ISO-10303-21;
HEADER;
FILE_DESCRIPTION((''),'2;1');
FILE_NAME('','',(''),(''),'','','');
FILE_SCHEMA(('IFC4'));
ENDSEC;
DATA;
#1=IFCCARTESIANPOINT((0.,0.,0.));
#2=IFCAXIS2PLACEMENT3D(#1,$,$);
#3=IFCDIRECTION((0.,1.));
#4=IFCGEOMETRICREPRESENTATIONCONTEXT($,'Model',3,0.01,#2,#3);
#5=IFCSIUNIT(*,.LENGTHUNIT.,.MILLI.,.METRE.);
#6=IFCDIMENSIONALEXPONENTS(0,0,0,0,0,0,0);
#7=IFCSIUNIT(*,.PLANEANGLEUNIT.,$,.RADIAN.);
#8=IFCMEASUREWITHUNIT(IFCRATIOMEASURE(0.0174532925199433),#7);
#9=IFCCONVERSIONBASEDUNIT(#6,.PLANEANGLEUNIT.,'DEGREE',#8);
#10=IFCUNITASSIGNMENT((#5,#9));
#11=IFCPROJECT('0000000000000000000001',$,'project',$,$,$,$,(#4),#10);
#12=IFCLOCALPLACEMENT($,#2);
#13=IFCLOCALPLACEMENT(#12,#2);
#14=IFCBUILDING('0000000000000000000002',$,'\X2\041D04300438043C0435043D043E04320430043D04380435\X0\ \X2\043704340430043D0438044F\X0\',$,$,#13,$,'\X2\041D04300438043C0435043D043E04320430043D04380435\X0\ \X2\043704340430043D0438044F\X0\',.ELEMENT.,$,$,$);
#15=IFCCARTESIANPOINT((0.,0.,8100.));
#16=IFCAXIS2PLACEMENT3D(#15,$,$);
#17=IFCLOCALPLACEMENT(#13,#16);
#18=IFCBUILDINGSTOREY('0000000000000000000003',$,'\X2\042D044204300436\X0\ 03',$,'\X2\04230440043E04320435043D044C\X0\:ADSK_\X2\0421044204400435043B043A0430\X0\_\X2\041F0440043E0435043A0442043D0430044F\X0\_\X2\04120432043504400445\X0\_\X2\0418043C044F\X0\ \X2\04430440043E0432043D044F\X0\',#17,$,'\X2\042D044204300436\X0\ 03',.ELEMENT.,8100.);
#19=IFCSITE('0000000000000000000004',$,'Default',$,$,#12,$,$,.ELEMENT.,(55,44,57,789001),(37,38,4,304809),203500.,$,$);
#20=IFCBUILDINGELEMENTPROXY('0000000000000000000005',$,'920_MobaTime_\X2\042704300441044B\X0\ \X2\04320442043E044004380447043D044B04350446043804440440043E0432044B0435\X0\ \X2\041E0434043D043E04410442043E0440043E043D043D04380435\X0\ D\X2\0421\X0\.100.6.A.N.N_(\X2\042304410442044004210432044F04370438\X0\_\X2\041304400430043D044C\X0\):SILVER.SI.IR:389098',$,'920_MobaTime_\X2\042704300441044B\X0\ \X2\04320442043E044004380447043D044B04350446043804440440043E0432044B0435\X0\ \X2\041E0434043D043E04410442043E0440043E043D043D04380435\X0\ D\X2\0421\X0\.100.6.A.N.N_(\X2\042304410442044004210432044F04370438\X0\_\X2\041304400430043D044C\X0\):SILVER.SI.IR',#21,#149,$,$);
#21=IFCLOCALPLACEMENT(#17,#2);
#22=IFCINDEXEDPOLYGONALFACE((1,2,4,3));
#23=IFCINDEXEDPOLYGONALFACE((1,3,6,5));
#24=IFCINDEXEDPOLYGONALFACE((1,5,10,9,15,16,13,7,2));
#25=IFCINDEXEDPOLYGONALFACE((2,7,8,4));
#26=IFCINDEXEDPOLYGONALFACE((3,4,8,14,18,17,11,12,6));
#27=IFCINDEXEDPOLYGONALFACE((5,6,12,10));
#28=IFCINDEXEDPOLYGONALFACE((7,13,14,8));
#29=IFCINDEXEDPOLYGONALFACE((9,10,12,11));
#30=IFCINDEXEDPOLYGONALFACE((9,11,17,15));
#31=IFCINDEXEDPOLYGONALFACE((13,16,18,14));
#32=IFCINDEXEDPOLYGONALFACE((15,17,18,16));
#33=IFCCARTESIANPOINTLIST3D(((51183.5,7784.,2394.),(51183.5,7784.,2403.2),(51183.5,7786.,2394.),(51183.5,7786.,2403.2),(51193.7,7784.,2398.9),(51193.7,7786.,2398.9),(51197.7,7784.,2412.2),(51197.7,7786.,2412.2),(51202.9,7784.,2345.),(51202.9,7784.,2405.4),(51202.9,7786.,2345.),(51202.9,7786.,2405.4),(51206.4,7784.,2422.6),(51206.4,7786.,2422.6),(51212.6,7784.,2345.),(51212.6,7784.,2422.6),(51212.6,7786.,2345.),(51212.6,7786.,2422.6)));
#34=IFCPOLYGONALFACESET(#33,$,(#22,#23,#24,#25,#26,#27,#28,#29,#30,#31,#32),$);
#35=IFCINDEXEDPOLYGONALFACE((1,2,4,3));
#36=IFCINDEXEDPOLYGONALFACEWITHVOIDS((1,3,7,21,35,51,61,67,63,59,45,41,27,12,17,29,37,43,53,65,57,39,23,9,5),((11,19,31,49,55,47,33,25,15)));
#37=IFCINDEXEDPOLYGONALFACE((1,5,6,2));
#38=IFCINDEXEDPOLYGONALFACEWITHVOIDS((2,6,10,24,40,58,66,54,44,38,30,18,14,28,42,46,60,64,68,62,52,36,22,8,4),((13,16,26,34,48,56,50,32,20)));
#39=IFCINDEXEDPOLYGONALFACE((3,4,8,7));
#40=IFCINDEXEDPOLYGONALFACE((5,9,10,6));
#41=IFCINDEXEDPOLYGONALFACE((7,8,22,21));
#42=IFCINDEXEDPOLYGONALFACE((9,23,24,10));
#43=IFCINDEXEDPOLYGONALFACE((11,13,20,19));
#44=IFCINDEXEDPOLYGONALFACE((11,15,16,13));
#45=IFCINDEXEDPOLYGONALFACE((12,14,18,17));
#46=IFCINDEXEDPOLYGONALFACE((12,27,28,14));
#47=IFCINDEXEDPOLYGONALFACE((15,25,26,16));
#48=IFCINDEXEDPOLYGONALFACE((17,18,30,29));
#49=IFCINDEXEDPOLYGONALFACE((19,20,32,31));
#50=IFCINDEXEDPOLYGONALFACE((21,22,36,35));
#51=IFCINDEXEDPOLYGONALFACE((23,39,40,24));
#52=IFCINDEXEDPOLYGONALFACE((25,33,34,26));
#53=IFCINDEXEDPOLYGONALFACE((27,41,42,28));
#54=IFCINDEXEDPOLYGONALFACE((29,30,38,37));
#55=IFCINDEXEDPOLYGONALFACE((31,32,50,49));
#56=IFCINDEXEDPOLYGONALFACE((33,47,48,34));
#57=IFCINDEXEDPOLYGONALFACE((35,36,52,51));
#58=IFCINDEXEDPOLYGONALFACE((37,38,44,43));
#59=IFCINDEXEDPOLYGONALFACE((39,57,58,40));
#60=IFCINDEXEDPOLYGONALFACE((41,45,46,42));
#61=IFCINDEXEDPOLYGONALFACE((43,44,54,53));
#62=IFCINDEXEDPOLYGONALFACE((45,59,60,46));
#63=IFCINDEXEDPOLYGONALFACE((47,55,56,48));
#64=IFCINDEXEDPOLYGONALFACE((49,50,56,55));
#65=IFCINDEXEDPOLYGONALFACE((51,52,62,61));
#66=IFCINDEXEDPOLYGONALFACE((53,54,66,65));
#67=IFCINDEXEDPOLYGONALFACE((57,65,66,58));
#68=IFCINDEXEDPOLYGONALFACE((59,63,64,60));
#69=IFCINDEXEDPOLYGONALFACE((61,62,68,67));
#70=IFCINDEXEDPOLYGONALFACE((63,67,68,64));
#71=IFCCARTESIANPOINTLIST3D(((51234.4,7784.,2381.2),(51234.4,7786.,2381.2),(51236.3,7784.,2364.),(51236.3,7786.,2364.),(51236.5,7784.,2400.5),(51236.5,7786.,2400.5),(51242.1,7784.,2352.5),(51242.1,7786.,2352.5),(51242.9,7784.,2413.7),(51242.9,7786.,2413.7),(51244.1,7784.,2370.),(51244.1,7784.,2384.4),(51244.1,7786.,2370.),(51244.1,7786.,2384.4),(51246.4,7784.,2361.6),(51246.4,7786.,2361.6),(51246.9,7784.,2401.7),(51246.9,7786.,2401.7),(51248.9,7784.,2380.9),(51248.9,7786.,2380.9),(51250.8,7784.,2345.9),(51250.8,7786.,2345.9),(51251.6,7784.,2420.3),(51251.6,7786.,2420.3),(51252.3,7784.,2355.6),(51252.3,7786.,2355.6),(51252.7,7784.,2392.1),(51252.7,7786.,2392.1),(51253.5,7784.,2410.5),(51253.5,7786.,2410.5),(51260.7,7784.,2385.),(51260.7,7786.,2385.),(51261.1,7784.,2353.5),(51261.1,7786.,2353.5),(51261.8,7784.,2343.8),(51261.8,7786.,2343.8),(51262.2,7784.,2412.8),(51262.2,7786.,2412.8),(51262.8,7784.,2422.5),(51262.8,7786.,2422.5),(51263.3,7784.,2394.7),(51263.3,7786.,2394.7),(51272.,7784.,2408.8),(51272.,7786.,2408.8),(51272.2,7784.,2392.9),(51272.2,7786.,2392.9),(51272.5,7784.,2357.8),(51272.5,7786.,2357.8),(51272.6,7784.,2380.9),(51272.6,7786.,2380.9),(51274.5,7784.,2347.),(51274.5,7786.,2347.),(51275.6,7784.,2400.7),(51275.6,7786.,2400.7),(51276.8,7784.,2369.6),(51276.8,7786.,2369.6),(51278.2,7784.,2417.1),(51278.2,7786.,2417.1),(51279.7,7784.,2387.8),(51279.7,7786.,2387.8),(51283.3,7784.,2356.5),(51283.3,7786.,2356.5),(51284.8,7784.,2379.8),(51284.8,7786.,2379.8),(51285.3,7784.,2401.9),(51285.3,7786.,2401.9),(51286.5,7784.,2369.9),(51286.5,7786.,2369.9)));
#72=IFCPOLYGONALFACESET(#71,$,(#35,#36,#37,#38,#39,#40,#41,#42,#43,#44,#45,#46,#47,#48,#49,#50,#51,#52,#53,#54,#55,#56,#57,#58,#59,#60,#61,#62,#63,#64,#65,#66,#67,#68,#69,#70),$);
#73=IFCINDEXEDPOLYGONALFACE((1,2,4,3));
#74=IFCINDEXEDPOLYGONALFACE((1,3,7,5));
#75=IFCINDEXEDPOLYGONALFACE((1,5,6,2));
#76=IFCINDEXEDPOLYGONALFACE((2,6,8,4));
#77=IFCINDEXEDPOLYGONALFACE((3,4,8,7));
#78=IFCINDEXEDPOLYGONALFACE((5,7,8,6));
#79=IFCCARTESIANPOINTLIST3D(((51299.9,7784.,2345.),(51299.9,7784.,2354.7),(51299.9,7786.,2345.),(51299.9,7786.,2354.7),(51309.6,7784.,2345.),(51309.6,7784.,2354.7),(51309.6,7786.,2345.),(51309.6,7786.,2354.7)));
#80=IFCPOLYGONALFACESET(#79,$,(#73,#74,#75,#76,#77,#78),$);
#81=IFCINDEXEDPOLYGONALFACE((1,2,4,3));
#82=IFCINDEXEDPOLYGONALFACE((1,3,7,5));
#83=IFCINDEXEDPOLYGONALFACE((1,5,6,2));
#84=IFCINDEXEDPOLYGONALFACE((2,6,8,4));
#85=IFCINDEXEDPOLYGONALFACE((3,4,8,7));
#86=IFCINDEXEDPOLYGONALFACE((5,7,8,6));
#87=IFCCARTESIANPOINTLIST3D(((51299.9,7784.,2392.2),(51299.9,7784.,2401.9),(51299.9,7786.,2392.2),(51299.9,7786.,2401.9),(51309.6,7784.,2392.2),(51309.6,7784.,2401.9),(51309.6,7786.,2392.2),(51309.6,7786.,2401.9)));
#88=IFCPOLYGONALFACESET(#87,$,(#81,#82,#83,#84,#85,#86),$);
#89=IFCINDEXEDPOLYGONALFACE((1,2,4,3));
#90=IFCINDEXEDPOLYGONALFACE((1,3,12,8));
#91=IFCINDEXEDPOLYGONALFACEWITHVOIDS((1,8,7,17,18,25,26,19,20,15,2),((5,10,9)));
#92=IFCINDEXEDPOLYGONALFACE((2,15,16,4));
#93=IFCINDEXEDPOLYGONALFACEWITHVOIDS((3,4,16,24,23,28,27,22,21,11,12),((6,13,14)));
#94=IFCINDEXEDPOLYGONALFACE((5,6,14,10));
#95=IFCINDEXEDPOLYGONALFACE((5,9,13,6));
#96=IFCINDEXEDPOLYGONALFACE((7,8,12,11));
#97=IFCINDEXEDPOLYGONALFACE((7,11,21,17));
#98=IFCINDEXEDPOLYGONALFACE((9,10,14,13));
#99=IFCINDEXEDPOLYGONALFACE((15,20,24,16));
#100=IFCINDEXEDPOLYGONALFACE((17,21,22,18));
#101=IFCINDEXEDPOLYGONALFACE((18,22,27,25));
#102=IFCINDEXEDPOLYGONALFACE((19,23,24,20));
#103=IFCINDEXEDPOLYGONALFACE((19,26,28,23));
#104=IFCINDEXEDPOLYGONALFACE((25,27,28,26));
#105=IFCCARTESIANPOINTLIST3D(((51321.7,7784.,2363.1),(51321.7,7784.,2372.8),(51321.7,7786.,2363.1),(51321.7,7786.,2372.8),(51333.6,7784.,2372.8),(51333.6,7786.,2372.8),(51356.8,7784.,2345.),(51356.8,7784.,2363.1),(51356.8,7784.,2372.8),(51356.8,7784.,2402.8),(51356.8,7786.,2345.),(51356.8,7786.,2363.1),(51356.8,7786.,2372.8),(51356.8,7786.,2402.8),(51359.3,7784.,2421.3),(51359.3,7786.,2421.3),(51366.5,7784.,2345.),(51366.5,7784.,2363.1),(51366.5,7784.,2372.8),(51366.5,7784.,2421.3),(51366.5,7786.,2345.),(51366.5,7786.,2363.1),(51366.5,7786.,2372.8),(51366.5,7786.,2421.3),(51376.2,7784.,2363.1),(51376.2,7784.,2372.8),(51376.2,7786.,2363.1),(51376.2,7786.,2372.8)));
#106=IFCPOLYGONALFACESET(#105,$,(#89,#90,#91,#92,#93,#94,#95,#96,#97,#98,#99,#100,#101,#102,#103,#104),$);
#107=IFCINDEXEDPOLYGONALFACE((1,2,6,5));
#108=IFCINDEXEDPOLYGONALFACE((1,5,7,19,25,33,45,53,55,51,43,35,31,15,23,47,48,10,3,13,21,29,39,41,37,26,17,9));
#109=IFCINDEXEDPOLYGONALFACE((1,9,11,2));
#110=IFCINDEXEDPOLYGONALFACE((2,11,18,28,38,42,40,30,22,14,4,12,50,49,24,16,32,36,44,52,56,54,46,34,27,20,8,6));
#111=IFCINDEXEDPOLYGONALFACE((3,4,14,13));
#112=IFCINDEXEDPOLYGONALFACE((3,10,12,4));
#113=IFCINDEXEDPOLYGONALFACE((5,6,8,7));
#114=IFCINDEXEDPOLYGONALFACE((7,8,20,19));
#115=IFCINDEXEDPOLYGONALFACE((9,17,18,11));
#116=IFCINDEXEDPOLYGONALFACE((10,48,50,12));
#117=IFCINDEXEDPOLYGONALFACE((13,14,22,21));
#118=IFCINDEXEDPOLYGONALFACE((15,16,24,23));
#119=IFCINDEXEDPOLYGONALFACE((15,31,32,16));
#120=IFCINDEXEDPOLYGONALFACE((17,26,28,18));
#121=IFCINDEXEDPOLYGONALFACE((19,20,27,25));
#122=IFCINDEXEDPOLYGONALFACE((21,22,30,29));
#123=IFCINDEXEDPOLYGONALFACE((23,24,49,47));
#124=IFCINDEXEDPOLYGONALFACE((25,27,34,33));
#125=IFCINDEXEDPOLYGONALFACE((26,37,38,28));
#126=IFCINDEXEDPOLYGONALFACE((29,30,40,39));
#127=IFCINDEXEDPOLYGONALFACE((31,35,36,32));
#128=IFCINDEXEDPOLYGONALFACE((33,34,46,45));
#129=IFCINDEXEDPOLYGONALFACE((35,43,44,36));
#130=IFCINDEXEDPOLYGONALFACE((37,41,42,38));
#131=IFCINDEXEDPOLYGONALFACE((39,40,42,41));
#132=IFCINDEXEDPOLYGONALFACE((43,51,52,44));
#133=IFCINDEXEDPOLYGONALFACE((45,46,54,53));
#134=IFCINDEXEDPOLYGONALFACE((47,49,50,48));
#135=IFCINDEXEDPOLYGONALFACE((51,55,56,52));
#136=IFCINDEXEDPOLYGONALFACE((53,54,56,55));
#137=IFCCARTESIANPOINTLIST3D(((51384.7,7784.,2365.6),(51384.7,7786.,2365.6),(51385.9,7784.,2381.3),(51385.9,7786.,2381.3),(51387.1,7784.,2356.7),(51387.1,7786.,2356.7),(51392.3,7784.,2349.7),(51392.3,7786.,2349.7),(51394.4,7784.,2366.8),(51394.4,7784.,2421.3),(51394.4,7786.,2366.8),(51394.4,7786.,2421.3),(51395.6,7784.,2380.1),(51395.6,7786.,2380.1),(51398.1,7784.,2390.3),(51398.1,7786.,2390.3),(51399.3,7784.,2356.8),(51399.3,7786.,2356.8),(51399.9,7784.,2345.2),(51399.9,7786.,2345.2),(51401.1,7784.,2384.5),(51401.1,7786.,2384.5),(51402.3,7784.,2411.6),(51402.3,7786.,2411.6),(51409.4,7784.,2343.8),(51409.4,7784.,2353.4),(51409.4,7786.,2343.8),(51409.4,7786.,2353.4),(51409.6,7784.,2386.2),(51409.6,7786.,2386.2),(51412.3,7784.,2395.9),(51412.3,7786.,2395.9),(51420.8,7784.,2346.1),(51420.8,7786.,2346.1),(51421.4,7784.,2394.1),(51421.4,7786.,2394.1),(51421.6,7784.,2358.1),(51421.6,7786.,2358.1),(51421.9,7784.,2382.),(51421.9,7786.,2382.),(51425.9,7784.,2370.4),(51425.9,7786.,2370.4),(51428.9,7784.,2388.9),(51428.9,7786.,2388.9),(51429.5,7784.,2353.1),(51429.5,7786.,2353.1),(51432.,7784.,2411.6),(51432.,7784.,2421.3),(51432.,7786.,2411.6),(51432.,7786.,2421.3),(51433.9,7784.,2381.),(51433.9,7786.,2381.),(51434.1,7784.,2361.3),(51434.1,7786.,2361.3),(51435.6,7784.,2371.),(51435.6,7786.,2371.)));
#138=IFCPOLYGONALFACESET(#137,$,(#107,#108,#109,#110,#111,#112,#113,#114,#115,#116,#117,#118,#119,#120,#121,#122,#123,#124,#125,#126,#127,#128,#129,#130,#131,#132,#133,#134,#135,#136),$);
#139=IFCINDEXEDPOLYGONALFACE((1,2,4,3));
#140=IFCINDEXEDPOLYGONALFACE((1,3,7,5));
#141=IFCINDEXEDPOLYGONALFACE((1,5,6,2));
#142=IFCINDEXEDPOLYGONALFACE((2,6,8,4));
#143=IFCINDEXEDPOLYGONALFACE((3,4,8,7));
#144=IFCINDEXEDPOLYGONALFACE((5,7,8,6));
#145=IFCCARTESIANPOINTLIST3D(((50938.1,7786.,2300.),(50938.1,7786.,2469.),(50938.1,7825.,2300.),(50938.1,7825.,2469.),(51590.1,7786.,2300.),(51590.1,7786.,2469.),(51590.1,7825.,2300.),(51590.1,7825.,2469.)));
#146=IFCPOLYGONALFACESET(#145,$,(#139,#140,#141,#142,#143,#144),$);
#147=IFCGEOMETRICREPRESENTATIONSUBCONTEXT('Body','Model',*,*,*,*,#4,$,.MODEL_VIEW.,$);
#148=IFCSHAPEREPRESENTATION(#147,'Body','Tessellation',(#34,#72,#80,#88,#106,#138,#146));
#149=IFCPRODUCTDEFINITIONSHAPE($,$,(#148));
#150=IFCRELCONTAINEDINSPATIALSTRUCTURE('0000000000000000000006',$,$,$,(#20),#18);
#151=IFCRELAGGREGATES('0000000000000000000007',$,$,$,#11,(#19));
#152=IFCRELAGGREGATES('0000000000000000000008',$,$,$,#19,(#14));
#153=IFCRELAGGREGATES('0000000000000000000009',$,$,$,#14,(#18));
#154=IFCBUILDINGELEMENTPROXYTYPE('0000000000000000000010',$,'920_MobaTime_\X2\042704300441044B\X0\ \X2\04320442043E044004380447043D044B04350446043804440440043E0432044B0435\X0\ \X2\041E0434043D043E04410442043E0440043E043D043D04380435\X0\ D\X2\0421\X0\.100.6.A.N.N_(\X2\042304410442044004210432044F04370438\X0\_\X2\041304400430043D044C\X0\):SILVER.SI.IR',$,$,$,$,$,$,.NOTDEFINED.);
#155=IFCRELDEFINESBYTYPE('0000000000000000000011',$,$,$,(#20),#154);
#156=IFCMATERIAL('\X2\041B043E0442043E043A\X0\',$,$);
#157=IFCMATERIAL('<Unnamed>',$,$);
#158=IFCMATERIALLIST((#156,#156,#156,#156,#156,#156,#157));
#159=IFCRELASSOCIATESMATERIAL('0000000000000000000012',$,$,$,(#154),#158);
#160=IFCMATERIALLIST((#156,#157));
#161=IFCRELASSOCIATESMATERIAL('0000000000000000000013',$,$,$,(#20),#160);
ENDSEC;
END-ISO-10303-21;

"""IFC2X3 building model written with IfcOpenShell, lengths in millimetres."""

from ifc_helpers import new_model, entity, si_unit, converted_unit, direction, frame, origin, origin_2d_with_axis, place, context, subcontext, project, spatial, polyline, rectangle, outline, extrude, source, transform, mapped, material, material_list, type_object, type_shapes, element, save


model = new_model("IFC2X3")

# Units and contexts
model_context = context("Model", 3, precision=0.01, world=origin(), true_north=direction((0.0, 1.0)))
body_context = subcontext(model_context, "Body", "Model", "MODEL_VIEW")
ifc_project = project(units=[si_unit("LENGTHUNIT", "METRE", prefix="MILLI"), converted_unit("PLANEANGLEUNIT", "DEGREE", entity("IfcRatioMeasure", 0.0174532925199433), si_unit("PLANEANGLEUNIT", "RADIAN"), dimensions=[0, 0, 0, 0, 0, 0, 0])], contexts=[model_context])

# Site, building, storey
site_placement = place(None, origin())
site = spatial("IfcSite", under=ifc_project, at=site_placement, Name="Default", CompositionType="ELEMENT", RefLatitude=(55, 44, 57, 789001), RefLongitude=(37, 38, 4, 304809), RefElevation=203500.0)
building_placement = place(site_placement, origin())
building = spatial("IfcBuilding", under=site, at=building_placement, Name="Наименование здания", LongName="Наименование здания", CompositionType="ELEMENT")
storey_placement = place(building_placement, frame((0.0, 0.0, 8100.0)))
storey = spatial("IfcBuildingStorey", under=building, at=storey_placement, Name="Этаж 03", ObjectType="Уровень:ADSK_Стрелка_Проектная_Вверх_Имя уровня", LongName="Этаж 03", CompositionType="ELEMENT", Elevation=8100.0)

# Building element proxy
ifc_material_1 = material(Name="Лоток")
ifc_material_2 = material(Name="<Unnamed>")
ifc_material_list_1 = material_list([ifc_material_1, ifc_material_1, ifc_material_1, ifc_material_1, ifc_material_1, ifc_material_1, ifc_material_2])
building_element_proxy_type = type_object("IfcBuildingElementProxyType", Name="920_MobaTime_Часы вторичныецифровые Односторонние DС.100.6.A.N.N_(УстрСвязи_Грань):SILVER.SI.IR", PredefinedType="NOTDEFINED", material=ifc_material_list_1)
shared_shape = source(origin(), body_context, "Body", "SweptSolid", [
    extrude(outline(polyline([(-49.3, -13.1), (28.2, -13.1), (28.2, -6.8), (17.9, 1.8), (8.8, 16.0), (-0.3, 16.0), (4.6, 5.8), (11.1, -3.4), (-49.3, -3.4), (-49.3, -13.1)])), frame((-64.6, 9.8, 39.0), z_axis=(0.0, 0.0, 1.0), x_axis=(0.0, 1.0, 0.0)), (0.0, 0.0, 1.0), 2.0),
    extrude(outline(polyline([(2.2, -27.6), (19.0, -27.6), (30.5, -16.1), (33.3, -4.9), (31.0, 5.8), (21.8, 17.2), (5.2, 27.3), (-11.1, 33.0), (-24.0, 32.7), (-33.6, 27.6), (-40.3, 18.6), (-42.8, 5.7), (-38.0, -6.3), (-27.2, -14.9), (-17.5, -17.7), (-8.2, -16.4), (-0.3, -11.9), (5.1, -4.5), (7.3, 6.2), (4.0, 17.2), (18.4, 7.3), (23.6, -2.4), (22.0, -11.4), (14.2, -18.4), (5.3, -18.3), (2.2, -27.6)]), holes=[polyline([(-9.0, 23.3), (-1.3, 14.3), (-2.5, 2.0), (-11.4, -7.0), (-23.4, -6.0), (-32.2, 2.9), (-31.2, 15.1), (-25.6, 22.1), (-17.5, 24.9), (-9.0, 23.3)])]), frame((-2.7, 3.6, 39.0), z_axis=(0.0, 0.0, 1.0), x_axis=(-0.427649, 0.903945, 0.0)), (0.0, 0.0, 1.0), 2.0),
    extrude(rectangle(XDim=9.7, YDim=9.7, at=origin_2d_with_axis()), frame((40.6, -34.7, 39.0)), (0.0, 0.0, 1.0), 2.0),
    extrude(rectangle(XDim=9.7, YDim=9.7, at=origin_2d_with_axis()), frame((40.6, 12.6, 39.0)), (0.0, 0.0, 1.0), 2.0),
    extrude(outline(polyline([(-0.9, -28.1), (8.8, -28.1), (8.8, -9.9), (18.5, -9.9), (18.5, -0.2), (8.8, -0.2), (8.8, 48.3), (1.5, 48.3), (-36.0, -0.2), (-36.0, -9.9), (-0.9, -9.9), (-0.9, -28.1)]), holes=[polyline([(-0.9, -0.2), (-24.1, -0.2), (-0.9, 29.7), (-0.9, -0.2)])]), frame((93.6, -11.4, 39.0)), (0.0, 0.0, 1.0), 2.0),
    extrude(outline(polyline([(3.3, -28.3), (12.5, -28.3), (20.5, -25.0), (26.8, -18.9), (30.7, -10.0), (31.4, 1.6), (26.9, 11.8), (20.1, 18.4), (11.1, 22.3), (1.0, 23.3), (-7.9, 20.4), (-14.9, 14.5), (-18.9, 6.2), (-17.1, -9.0), (-36.7, 0.5), (-29.1, 29.2), (-38.5, 31.7), (-48.1, -4.6), (-11.6, -23.1), (-8.0, -14.0), (-10.8, -7.6), (-10.2, 1.1), (-3.0, 11.8), (9.2, 12.8), (20.0, 5.5), (21.4, -7.5), (15.5, -16.4), (4.6, -18.6), (3.3, -28.3)])), frame((147.1, -8.5, 39.0), z_axis=(0.0, 0.0, 1.0), x_axis=(0.256974, -0.966418, 0.0)), (0.0, 0.0, 1.0), 2.0),
    extrude(rectangle(XDim=652.0, YDim=169.0, at=origin_2d_with_axis()), frame((0.0, 0.0, 0.0), z_axis=(0.0, 0.0, 1.0), x_axis=(-1.0, 0.0, 0.0)), (0.0, 0.0, 1.0), 39.0),
])
type_shapes(building_element_proxy_type, [shared_shape])
ifc_material_list_2 = material_list([ifc_material_1, ifc_material_2])
for number, where, z_axis, x_axis, name in (
    (1, (51264.1, 7825.0, 2384.5), (0.0, -1.0, 0.0), (1.0, 0.0, 0.0), "920_MobaTime_Часы вторичныецифровые Односторонние DС.100.6.A.N.N_(УстрСвязи_Грань):SILVER.SI.IR:389098"),
):
    element("IfcBuildingElementProxy", number, at=place(storey_placement, frame(where, z_axis=z_axis, x_axis=x_axis)), inside=storey, type_object=building_element_proxy_type, material=ifc_material_list_2, Name=name, ObjectType="920_MobaTime_Часы вторичныецифровые Односторонние DС.100.6.A.N.N_(УстрСвязи_Грань):SILVER.SI.IR", context=body_context, shape_type="MappedRepresentation", body=[
        mapped(shared_shape, transform((0.0, 0.0, 0.0), scale=1.0)),
    ])

save(model, "model.ifc")
